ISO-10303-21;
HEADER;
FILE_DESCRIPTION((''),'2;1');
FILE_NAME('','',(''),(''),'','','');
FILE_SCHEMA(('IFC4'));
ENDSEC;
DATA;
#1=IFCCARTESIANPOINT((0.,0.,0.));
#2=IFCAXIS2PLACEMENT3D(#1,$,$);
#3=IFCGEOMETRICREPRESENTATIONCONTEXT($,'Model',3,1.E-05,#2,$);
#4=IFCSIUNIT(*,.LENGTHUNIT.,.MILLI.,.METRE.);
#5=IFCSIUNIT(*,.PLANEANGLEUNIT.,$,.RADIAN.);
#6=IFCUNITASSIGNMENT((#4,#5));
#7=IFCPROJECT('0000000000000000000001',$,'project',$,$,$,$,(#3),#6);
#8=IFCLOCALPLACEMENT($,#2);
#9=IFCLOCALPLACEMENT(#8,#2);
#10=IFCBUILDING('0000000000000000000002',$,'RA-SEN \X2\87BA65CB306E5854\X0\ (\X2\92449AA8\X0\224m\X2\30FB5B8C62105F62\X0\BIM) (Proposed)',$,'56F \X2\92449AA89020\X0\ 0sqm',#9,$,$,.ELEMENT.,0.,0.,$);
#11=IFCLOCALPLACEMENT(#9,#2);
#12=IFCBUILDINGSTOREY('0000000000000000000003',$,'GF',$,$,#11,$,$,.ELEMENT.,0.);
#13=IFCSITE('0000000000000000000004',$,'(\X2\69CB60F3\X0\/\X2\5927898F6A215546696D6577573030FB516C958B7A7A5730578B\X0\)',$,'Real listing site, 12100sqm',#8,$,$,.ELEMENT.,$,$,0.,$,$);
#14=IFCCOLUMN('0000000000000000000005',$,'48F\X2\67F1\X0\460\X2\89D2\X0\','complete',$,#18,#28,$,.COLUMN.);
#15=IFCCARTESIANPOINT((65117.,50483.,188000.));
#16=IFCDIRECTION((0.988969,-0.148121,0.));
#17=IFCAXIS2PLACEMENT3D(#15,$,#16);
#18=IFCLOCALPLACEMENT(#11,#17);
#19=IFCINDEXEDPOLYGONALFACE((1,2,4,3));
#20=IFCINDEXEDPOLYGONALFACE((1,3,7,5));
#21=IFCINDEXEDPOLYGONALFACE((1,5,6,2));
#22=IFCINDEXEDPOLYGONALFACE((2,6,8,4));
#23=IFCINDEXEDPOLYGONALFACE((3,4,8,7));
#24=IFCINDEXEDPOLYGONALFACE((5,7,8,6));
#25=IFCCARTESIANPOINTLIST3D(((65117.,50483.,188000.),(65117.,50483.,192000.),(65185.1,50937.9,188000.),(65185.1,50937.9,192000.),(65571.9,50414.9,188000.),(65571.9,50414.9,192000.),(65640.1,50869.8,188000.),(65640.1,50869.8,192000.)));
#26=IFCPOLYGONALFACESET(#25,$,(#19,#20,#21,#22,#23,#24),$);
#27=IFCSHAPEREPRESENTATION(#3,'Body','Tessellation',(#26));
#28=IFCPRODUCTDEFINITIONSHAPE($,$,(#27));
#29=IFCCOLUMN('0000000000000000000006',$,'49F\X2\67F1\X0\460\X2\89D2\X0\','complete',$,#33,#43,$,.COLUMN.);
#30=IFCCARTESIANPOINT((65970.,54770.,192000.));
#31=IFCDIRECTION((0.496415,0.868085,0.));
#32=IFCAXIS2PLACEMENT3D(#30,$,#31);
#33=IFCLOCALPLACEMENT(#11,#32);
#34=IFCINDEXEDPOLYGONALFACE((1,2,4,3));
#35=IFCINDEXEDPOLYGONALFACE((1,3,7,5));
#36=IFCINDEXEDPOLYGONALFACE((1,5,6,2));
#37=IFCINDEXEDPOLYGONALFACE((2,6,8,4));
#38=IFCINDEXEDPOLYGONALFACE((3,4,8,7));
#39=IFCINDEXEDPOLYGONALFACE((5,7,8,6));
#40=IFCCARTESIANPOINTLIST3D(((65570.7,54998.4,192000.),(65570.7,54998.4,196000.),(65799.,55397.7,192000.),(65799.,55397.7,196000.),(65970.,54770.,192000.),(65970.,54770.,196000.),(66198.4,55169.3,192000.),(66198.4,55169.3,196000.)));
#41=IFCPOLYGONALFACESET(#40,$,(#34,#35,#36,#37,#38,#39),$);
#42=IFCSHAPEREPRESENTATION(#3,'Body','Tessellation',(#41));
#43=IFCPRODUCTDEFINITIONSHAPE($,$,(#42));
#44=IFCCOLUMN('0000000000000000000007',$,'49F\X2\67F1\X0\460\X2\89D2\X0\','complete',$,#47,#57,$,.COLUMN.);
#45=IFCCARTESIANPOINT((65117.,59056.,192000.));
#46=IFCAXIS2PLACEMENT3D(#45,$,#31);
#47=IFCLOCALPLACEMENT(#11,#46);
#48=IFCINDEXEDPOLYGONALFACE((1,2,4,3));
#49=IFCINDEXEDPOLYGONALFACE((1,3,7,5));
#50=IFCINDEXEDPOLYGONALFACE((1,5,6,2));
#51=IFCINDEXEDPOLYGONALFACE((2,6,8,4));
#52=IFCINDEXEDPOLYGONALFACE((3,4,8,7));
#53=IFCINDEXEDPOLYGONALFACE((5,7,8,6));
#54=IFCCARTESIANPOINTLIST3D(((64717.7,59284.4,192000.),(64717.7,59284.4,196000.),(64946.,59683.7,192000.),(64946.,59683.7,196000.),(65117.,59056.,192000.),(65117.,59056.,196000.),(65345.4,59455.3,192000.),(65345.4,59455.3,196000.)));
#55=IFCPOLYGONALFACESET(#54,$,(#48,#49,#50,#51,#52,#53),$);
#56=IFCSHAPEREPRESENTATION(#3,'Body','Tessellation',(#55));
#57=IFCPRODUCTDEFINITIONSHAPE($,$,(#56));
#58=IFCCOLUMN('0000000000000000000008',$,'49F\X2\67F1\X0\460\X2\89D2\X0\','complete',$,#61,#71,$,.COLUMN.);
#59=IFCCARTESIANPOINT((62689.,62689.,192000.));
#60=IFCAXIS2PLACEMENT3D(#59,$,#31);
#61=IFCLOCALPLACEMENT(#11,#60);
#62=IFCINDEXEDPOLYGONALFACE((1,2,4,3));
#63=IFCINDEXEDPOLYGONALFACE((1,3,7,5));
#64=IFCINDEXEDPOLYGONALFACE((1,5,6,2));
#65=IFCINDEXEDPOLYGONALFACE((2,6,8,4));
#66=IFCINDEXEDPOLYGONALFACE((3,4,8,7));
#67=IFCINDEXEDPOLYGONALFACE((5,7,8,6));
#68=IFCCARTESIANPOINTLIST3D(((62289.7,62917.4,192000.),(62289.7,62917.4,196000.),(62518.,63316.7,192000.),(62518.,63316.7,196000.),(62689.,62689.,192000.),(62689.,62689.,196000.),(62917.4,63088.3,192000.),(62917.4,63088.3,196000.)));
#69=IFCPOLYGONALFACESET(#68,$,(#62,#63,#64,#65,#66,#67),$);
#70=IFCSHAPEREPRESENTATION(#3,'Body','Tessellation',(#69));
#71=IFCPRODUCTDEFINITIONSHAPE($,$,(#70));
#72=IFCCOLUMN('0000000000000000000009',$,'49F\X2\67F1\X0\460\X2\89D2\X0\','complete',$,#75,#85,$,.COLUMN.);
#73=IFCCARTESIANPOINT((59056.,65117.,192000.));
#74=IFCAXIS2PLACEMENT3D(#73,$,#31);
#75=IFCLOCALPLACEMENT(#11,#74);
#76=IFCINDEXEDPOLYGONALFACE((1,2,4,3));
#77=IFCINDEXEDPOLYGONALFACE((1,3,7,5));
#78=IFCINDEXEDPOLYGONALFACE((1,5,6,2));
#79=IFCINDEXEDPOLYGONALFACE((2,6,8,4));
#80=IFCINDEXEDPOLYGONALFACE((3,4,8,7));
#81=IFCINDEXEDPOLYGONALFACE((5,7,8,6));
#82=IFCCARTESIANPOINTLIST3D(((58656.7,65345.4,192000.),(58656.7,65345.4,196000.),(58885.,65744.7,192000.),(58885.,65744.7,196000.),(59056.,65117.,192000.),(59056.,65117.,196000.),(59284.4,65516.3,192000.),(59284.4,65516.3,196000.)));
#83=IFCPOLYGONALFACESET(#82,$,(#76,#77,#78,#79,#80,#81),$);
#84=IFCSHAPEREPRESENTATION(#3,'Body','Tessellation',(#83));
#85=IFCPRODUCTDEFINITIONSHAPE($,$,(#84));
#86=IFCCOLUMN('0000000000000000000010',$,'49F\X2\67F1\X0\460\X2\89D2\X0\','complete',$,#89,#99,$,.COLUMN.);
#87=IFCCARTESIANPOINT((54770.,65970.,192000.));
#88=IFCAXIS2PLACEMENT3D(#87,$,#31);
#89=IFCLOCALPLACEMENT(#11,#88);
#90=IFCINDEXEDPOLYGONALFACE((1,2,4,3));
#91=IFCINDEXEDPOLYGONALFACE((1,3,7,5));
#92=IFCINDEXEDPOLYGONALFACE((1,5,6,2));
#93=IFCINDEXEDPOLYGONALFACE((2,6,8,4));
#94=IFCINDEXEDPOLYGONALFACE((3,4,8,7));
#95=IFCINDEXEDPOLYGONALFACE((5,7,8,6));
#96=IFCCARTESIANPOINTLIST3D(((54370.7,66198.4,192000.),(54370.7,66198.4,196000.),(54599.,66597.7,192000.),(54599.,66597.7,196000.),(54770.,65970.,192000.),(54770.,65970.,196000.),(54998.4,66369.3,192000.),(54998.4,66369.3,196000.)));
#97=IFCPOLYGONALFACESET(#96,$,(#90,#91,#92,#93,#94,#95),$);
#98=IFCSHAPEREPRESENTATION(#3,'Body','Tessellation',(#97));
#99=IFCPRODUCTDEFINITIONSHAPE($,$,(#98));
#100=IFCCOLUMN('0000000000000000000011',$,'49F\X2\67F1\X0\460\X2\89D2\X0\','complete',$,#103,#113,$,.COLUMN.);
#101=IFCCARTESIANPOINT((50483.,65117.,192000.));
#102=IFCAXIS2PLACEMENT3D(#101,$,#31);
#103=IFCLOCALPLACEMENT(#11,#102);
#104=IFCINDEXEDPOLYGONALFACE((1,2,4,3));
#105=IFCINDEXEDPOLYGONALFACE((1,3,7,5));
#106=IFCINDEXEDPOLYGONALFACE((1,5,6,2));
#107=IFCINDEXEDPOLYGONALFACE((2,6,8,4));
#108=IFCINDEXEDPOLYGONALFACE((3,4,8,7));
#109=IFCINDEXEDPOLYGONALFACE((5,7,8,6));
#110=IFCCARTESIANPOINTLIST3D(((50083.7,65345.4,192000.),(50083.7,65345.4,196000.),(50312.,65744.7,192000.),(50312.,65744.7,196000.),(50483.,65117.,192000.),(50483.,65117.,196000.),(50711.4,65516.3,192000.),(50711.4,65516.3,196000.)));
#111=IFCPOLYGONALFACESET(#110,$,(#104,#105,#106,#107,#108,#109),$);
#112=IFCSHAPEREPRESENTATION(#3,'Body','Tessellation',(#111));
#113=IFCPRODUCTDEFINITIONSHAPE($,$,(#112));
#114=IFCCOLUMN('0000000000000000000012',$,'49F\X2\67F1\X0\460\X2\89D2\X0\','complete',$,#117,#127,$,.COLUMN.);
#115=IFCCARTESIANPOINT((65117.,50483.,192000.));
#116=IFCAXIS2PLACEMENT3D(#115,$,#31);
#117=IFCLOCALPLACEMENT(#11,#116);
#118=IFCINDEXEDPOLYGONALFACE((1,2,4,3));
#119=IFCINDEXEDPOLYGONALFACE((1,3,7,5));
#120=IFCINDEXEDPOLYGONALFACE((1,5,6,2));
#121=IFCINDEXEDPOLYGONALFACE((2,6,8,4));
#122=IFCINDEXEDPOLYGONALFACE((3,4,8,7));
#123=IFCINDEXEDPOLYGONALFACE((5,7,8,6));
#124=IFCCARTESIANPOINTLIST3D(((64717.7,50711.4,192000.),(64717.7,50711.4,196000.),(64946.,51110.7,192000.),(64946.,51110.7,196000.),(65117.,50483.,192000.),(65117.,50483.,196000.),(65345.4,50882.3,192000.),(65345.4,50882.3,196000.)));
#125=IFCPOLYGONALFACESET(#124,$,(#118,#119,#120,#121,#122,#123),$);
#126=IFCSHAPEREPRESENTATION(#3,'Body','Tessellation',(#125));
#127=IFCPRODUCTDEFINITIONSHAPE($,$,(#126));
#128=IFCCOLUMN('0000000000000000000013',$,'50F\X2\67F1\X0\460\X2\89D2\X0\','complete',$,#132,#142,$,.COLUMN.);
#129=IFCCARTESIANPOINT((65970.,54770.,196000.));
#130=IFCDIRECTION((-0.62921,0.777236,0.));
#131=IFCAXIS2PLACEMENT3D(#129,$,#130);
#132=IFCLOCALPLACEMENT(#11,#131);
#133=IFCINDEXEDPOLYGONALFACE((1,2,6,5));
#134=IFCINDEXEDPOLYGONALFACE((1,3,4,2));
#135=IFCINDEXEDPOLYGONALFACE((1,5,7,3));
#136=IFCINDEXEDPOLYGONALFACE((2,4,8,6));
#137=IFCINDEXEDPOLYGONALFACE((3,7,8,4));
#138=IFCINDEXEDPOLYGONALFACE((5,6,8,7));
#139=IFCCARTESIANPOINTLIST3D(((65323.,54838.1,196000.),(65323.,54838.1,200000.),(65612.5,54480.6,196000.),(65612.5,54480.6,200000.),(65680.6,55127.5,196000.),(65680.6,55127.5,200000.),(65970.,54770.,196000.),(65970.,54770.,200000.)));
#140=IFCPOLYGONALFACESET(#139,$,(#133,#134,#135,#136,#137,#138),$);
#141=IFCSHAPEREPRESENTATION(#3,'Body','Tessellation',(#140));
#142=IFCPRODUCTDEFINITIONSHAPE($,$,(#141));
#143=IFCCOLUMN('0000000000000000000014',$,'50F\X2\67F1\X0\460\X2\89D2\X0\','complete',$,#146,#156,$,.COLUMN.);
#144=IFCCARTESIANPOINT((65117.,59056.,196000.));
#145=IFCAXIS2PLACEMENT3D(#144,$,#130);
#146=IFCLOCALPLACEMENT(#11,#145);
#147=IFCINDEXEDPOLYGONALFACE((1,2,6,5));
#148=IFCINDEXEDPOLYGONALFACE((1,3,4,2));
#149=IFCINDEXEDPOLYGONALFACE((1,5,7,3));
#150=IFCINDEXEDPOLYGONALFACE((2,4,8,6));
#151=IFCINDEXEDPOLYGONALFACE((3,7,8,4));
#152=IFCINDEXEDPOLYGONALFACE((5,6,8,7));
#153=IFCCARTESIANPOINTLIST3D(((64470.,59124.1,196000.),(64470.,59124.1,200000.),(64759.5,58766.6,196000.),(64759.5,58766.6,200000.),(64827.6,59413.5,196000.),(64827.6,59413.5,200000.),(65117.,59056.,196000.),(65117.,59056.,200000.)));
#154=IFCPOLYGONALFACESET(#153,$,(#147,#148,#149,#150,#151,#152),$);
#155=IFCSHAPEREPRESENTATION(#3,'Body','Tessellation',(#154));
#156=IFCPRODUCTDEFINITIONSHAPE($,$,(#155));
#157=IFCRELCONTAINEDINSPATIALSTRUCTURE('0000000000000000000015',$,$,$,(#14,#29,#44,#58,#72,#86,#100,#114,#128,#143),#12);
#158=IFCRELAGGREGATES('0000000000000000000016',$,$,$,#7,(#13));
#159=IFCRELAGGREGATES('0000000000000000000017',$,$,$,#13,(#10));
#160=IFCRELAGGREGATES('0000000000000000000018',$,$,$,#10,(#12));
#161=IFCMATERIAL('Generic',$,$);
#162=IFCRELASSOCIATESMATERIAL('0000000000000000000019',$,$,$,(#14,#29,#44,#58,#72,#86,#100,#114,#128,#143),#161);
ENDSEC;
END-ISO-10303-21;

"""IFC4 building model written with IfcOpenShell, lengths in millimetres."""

from ifc_helpers import new_model, si_unit, frame, frame_2d, origin, place, context, project, spatial, rectangle, extrude, material, element, save


model = new_model("IFC4")

# Units and contexts
model_context = context("Model", 3, precision=1e-05, world=origin())
ifc_project = project(units=[si_unit("LENGTHUNIT", "METRE", prefix="MILLI"), si_unit("PLANEANGLEUNIT", "RADIAN")], contexts=[model_context])

# Site, building, storey
site_placement = place(None, origin())
site = spatial("IfcSite", under=ifc_project, at=site_placement, Name="(構想/大規模商業敷地・公開空地型)", ObjectType="Real listing site, 12100sqm", CompositionType="ELEMENT", RefElevation=0.0)
building_placement = place(site_placement, origin())
building = spatial("IfcBuilding", under=site, at=building_placement, Name="RA-SEN 螺旋の塔 (鉄骨224m・完成形BIM) (Proposed)", ObjectType="56F 鉄骨造 0sqm", CompositionType="ELEMENT", ElevationOfRefHeight=0.0, ElevationOfTerrain=0.0)
storey_placement = place(building_placement, origin())
storey = spatial("IfcBuildingStorey", under=building, at=storey_placement, Name="GF", CompositionType="ELEMENT", Elevation=0.0)

# Columns
ifc_material = material(Name="Generic")
column_1_placement = place(storey_placement, frame((65117.0, 50483.0, 188000.0), x_axis=(0.988969, -0.148121, 0.0)))
element("IfcColumn", 1, at=column_1_placement, inside=storey, material=ifc_material, Name="48F柱460角", Description="complete", PredefinedType="COLUMN", context=model_context, shape_type="SweptSolid", body=[
    extrude(rectangle(XDim=460.0, YDim=460.0, at=frame_2d((230.0, 230.0))), frame((65117.0, 50483.0, 188000.0), x_axis=(0.988969, -0.148121, 0.0)), (0.0, 0.0, 1.0), 4000.0),
])
column_2_placement = place(storey_placement, frame((65970.0, 54770.0, 192000.0), x_axis=(0.496415, 0.868085, 0.0)))
element("IfcColumn", 2, at=column_2_placement, inside=storey, material=ifc_material, Name="49F柱460角", Description="complete", PredefinedType="COLUMN", context=model_context, shape_type="SweptSolid", body=[
    extrude(rectangle(XDim=460.0, YDim=460.0, at=frame_2d((230.0, 230.0))), frame((65970.0, 54770.0, 192000.0), x_axis=(0.496415, 0.868085, 0.0)), (0.0, 0.0, 1.0), 4000.0),
])
column_3_placement = place(storey_placement, frame((65117.0, 59056.0, 192000.0), x_axis=(0.496415, 0.868085, 0.0)))
element("IfcColumn", 3, at=column_3_placement, inside=storey, material=ifc_material, Name="49F柱460角", Description="complete", PredefinedType="COLUMN", context=model_context, shape_type="SweptSolid", body=[
    extrude(rectangle(XDim=460.0, YDim=460.0, at=frame_2d((230.0, 230.0))), frame((65117.0, 59056.0, 192000.0), x_axis=(0.496415, 0.868085, 0.0)), (0.0, 0.0, 1.0), 4000.0),
])
column_4_placement = place(storey_placement, frame((62689.0, 62689.0, 192000.0), x_axis=(0.496415, 0.868085, 0.0)))
element("IfcColumn", 4, at=column_4_placement, inside=storey, material=ifc_material, Name="49F柱460角", Description="complete", PredefinedType="COLUMN", context=model_context, shape_type="SweptSolid", body=[
    extrude(rectangle(XDim=460.0, YDim=460.0, at=frame_2d((230.0, 230.0))), frame((62689.0, 62689.0, 192000.0), x_axis=(0.496415, 0.868085, 0.0)), (0.0, 0.0, 1.0), 4000.0),
])
column_5_placement = place(storey_placement, frame((59056.0, 65117.0, 192000.0), x_axis=(0.496415, 0.868085, 0.0)))
element("IfcColumn", 5, at=column_5_placement, inside=storey, material=ifc_material, Name="49F柱460角", Description="complete", PredefinedType="COLUMN", context=model_context, shape_type="SweptSolid", body=[
    extrude(rectangle(XDim=460.0, YDim=460.0, at=frame_2d((230.0, 230.0))), frame((59056.0, 65117.0, 192000.0), x_axis=(0.496415, 0.868085, 0.0)), (0.0, 0.0, 1.0), 4000.0),
])
column_6_placement = place(storey_placement, frame((54770.0, 65970.0, 192000.0), x_axis=(0.496415, 0.868085, 0.0)))
element("IfcColumn", 6, at=column_6_placement, inside=storey, material=ifc_material, Name="49F柱460角", Description="complete", PredefinedType="COLUMN", context=model_context, shape_type="SweptSolid", body=[
    extrude(rectangle(XDim=460.0, YDim=460.0, at=frame_2d((230.0, 230.0))), frame((54770.0, 65970.0, 192000.0), x_axis=(0.496415, 0.868085, 0.0)), (0.0, 0.0, 1.0), 4000.0),
])
column_7_placement = place(storey_placement, frame((50483.0, 65117.0, 192000.0), x_axis=(0.496415, 0.868085, 0.0)))
element("IfcColumn", 7, at=column_7_placement, inside=storey, material=ifc_material, Name="49F柱460角", Description="complete", PredefinedType="COLUMN", context=model_context, shape_type="SweptSolid", body=[
    extrude(rectangle(XDim=460.0, YDim=460.0, at=frame_2d((230.0, 230.0))), frame((50483.0, 65117.0, 192000.0), x_axis=(0.496415, 0.868085, 0.0)), (0.0, 0.0, 1.0), 4000.0),
])
column_8_placement = place(storey_placement, frame((65117.0, 50483.0, 192000.0), x_axis=(0.496415, 0.868085, 0.0)))
element("IfcColumn", 8, at=column_8_placement, inside=storey, material=ifc_material, Name="49F柱460角", Description="complete", PredefinedType="COLUMN", context=model_context, shape_type="SweptSolid", body=[
    extrude(rectangle(XDim=460.0, YDim=460.0, at=frame_2d((230.0, 230.0))), frame((65117.0, 50483.0, 192000.0), x_axis=(0.496415, 0.868085, 0.0)), (0.0, 0.0, 1.0), 4000.0),
])
column_9_placement = place(storey_placement, frame((65970.0, 54770.0, 196000.0), x_axis=(-0.62921, 0.777236, 0.0)))
element("IfcColumn", 9, at=column_9_placement, inside=storey, material=ifc_material, Name="50F柱460角", Description="complete", PredefinedType="COLUMN", context=model_context, shape_type="SweptSolid", body=[
    extrude(rectangle(XDim=460.0, YDim=460.0, at=frame_2d((230.0, 230.0))), frame((65970.0, 54770.0, 196000.0), x_axis=(-0.62921, 0.777236, 0.0)), (0.0, 0.0, 1.0), 4000.0),
])
column_10_placement = place(storey_placement, frame((65117.0, 59056.0, 196000.0), x_axis=(-0.62921, 0.777236, 0.0)))
element("IfcColumn", 10, at=column_10_placement, inside=storey, material=ifc_material, Name="50F柱460角", Description="complete", PredefinedType="COLUMN", context=model_context, shape_type="SweptSolid", body=[
    extrude(rectangle(XDim=460.0, YDim=460.0, at=frame_2d((230.0, 230.0))), frame((65117.0, 59056.0, 196000.0), x_axis=(-0.62921, 0.777236, 0.0)), (0.0, 0.0, 1.0), 4000.0),
])

save(model, "model.ifc")
